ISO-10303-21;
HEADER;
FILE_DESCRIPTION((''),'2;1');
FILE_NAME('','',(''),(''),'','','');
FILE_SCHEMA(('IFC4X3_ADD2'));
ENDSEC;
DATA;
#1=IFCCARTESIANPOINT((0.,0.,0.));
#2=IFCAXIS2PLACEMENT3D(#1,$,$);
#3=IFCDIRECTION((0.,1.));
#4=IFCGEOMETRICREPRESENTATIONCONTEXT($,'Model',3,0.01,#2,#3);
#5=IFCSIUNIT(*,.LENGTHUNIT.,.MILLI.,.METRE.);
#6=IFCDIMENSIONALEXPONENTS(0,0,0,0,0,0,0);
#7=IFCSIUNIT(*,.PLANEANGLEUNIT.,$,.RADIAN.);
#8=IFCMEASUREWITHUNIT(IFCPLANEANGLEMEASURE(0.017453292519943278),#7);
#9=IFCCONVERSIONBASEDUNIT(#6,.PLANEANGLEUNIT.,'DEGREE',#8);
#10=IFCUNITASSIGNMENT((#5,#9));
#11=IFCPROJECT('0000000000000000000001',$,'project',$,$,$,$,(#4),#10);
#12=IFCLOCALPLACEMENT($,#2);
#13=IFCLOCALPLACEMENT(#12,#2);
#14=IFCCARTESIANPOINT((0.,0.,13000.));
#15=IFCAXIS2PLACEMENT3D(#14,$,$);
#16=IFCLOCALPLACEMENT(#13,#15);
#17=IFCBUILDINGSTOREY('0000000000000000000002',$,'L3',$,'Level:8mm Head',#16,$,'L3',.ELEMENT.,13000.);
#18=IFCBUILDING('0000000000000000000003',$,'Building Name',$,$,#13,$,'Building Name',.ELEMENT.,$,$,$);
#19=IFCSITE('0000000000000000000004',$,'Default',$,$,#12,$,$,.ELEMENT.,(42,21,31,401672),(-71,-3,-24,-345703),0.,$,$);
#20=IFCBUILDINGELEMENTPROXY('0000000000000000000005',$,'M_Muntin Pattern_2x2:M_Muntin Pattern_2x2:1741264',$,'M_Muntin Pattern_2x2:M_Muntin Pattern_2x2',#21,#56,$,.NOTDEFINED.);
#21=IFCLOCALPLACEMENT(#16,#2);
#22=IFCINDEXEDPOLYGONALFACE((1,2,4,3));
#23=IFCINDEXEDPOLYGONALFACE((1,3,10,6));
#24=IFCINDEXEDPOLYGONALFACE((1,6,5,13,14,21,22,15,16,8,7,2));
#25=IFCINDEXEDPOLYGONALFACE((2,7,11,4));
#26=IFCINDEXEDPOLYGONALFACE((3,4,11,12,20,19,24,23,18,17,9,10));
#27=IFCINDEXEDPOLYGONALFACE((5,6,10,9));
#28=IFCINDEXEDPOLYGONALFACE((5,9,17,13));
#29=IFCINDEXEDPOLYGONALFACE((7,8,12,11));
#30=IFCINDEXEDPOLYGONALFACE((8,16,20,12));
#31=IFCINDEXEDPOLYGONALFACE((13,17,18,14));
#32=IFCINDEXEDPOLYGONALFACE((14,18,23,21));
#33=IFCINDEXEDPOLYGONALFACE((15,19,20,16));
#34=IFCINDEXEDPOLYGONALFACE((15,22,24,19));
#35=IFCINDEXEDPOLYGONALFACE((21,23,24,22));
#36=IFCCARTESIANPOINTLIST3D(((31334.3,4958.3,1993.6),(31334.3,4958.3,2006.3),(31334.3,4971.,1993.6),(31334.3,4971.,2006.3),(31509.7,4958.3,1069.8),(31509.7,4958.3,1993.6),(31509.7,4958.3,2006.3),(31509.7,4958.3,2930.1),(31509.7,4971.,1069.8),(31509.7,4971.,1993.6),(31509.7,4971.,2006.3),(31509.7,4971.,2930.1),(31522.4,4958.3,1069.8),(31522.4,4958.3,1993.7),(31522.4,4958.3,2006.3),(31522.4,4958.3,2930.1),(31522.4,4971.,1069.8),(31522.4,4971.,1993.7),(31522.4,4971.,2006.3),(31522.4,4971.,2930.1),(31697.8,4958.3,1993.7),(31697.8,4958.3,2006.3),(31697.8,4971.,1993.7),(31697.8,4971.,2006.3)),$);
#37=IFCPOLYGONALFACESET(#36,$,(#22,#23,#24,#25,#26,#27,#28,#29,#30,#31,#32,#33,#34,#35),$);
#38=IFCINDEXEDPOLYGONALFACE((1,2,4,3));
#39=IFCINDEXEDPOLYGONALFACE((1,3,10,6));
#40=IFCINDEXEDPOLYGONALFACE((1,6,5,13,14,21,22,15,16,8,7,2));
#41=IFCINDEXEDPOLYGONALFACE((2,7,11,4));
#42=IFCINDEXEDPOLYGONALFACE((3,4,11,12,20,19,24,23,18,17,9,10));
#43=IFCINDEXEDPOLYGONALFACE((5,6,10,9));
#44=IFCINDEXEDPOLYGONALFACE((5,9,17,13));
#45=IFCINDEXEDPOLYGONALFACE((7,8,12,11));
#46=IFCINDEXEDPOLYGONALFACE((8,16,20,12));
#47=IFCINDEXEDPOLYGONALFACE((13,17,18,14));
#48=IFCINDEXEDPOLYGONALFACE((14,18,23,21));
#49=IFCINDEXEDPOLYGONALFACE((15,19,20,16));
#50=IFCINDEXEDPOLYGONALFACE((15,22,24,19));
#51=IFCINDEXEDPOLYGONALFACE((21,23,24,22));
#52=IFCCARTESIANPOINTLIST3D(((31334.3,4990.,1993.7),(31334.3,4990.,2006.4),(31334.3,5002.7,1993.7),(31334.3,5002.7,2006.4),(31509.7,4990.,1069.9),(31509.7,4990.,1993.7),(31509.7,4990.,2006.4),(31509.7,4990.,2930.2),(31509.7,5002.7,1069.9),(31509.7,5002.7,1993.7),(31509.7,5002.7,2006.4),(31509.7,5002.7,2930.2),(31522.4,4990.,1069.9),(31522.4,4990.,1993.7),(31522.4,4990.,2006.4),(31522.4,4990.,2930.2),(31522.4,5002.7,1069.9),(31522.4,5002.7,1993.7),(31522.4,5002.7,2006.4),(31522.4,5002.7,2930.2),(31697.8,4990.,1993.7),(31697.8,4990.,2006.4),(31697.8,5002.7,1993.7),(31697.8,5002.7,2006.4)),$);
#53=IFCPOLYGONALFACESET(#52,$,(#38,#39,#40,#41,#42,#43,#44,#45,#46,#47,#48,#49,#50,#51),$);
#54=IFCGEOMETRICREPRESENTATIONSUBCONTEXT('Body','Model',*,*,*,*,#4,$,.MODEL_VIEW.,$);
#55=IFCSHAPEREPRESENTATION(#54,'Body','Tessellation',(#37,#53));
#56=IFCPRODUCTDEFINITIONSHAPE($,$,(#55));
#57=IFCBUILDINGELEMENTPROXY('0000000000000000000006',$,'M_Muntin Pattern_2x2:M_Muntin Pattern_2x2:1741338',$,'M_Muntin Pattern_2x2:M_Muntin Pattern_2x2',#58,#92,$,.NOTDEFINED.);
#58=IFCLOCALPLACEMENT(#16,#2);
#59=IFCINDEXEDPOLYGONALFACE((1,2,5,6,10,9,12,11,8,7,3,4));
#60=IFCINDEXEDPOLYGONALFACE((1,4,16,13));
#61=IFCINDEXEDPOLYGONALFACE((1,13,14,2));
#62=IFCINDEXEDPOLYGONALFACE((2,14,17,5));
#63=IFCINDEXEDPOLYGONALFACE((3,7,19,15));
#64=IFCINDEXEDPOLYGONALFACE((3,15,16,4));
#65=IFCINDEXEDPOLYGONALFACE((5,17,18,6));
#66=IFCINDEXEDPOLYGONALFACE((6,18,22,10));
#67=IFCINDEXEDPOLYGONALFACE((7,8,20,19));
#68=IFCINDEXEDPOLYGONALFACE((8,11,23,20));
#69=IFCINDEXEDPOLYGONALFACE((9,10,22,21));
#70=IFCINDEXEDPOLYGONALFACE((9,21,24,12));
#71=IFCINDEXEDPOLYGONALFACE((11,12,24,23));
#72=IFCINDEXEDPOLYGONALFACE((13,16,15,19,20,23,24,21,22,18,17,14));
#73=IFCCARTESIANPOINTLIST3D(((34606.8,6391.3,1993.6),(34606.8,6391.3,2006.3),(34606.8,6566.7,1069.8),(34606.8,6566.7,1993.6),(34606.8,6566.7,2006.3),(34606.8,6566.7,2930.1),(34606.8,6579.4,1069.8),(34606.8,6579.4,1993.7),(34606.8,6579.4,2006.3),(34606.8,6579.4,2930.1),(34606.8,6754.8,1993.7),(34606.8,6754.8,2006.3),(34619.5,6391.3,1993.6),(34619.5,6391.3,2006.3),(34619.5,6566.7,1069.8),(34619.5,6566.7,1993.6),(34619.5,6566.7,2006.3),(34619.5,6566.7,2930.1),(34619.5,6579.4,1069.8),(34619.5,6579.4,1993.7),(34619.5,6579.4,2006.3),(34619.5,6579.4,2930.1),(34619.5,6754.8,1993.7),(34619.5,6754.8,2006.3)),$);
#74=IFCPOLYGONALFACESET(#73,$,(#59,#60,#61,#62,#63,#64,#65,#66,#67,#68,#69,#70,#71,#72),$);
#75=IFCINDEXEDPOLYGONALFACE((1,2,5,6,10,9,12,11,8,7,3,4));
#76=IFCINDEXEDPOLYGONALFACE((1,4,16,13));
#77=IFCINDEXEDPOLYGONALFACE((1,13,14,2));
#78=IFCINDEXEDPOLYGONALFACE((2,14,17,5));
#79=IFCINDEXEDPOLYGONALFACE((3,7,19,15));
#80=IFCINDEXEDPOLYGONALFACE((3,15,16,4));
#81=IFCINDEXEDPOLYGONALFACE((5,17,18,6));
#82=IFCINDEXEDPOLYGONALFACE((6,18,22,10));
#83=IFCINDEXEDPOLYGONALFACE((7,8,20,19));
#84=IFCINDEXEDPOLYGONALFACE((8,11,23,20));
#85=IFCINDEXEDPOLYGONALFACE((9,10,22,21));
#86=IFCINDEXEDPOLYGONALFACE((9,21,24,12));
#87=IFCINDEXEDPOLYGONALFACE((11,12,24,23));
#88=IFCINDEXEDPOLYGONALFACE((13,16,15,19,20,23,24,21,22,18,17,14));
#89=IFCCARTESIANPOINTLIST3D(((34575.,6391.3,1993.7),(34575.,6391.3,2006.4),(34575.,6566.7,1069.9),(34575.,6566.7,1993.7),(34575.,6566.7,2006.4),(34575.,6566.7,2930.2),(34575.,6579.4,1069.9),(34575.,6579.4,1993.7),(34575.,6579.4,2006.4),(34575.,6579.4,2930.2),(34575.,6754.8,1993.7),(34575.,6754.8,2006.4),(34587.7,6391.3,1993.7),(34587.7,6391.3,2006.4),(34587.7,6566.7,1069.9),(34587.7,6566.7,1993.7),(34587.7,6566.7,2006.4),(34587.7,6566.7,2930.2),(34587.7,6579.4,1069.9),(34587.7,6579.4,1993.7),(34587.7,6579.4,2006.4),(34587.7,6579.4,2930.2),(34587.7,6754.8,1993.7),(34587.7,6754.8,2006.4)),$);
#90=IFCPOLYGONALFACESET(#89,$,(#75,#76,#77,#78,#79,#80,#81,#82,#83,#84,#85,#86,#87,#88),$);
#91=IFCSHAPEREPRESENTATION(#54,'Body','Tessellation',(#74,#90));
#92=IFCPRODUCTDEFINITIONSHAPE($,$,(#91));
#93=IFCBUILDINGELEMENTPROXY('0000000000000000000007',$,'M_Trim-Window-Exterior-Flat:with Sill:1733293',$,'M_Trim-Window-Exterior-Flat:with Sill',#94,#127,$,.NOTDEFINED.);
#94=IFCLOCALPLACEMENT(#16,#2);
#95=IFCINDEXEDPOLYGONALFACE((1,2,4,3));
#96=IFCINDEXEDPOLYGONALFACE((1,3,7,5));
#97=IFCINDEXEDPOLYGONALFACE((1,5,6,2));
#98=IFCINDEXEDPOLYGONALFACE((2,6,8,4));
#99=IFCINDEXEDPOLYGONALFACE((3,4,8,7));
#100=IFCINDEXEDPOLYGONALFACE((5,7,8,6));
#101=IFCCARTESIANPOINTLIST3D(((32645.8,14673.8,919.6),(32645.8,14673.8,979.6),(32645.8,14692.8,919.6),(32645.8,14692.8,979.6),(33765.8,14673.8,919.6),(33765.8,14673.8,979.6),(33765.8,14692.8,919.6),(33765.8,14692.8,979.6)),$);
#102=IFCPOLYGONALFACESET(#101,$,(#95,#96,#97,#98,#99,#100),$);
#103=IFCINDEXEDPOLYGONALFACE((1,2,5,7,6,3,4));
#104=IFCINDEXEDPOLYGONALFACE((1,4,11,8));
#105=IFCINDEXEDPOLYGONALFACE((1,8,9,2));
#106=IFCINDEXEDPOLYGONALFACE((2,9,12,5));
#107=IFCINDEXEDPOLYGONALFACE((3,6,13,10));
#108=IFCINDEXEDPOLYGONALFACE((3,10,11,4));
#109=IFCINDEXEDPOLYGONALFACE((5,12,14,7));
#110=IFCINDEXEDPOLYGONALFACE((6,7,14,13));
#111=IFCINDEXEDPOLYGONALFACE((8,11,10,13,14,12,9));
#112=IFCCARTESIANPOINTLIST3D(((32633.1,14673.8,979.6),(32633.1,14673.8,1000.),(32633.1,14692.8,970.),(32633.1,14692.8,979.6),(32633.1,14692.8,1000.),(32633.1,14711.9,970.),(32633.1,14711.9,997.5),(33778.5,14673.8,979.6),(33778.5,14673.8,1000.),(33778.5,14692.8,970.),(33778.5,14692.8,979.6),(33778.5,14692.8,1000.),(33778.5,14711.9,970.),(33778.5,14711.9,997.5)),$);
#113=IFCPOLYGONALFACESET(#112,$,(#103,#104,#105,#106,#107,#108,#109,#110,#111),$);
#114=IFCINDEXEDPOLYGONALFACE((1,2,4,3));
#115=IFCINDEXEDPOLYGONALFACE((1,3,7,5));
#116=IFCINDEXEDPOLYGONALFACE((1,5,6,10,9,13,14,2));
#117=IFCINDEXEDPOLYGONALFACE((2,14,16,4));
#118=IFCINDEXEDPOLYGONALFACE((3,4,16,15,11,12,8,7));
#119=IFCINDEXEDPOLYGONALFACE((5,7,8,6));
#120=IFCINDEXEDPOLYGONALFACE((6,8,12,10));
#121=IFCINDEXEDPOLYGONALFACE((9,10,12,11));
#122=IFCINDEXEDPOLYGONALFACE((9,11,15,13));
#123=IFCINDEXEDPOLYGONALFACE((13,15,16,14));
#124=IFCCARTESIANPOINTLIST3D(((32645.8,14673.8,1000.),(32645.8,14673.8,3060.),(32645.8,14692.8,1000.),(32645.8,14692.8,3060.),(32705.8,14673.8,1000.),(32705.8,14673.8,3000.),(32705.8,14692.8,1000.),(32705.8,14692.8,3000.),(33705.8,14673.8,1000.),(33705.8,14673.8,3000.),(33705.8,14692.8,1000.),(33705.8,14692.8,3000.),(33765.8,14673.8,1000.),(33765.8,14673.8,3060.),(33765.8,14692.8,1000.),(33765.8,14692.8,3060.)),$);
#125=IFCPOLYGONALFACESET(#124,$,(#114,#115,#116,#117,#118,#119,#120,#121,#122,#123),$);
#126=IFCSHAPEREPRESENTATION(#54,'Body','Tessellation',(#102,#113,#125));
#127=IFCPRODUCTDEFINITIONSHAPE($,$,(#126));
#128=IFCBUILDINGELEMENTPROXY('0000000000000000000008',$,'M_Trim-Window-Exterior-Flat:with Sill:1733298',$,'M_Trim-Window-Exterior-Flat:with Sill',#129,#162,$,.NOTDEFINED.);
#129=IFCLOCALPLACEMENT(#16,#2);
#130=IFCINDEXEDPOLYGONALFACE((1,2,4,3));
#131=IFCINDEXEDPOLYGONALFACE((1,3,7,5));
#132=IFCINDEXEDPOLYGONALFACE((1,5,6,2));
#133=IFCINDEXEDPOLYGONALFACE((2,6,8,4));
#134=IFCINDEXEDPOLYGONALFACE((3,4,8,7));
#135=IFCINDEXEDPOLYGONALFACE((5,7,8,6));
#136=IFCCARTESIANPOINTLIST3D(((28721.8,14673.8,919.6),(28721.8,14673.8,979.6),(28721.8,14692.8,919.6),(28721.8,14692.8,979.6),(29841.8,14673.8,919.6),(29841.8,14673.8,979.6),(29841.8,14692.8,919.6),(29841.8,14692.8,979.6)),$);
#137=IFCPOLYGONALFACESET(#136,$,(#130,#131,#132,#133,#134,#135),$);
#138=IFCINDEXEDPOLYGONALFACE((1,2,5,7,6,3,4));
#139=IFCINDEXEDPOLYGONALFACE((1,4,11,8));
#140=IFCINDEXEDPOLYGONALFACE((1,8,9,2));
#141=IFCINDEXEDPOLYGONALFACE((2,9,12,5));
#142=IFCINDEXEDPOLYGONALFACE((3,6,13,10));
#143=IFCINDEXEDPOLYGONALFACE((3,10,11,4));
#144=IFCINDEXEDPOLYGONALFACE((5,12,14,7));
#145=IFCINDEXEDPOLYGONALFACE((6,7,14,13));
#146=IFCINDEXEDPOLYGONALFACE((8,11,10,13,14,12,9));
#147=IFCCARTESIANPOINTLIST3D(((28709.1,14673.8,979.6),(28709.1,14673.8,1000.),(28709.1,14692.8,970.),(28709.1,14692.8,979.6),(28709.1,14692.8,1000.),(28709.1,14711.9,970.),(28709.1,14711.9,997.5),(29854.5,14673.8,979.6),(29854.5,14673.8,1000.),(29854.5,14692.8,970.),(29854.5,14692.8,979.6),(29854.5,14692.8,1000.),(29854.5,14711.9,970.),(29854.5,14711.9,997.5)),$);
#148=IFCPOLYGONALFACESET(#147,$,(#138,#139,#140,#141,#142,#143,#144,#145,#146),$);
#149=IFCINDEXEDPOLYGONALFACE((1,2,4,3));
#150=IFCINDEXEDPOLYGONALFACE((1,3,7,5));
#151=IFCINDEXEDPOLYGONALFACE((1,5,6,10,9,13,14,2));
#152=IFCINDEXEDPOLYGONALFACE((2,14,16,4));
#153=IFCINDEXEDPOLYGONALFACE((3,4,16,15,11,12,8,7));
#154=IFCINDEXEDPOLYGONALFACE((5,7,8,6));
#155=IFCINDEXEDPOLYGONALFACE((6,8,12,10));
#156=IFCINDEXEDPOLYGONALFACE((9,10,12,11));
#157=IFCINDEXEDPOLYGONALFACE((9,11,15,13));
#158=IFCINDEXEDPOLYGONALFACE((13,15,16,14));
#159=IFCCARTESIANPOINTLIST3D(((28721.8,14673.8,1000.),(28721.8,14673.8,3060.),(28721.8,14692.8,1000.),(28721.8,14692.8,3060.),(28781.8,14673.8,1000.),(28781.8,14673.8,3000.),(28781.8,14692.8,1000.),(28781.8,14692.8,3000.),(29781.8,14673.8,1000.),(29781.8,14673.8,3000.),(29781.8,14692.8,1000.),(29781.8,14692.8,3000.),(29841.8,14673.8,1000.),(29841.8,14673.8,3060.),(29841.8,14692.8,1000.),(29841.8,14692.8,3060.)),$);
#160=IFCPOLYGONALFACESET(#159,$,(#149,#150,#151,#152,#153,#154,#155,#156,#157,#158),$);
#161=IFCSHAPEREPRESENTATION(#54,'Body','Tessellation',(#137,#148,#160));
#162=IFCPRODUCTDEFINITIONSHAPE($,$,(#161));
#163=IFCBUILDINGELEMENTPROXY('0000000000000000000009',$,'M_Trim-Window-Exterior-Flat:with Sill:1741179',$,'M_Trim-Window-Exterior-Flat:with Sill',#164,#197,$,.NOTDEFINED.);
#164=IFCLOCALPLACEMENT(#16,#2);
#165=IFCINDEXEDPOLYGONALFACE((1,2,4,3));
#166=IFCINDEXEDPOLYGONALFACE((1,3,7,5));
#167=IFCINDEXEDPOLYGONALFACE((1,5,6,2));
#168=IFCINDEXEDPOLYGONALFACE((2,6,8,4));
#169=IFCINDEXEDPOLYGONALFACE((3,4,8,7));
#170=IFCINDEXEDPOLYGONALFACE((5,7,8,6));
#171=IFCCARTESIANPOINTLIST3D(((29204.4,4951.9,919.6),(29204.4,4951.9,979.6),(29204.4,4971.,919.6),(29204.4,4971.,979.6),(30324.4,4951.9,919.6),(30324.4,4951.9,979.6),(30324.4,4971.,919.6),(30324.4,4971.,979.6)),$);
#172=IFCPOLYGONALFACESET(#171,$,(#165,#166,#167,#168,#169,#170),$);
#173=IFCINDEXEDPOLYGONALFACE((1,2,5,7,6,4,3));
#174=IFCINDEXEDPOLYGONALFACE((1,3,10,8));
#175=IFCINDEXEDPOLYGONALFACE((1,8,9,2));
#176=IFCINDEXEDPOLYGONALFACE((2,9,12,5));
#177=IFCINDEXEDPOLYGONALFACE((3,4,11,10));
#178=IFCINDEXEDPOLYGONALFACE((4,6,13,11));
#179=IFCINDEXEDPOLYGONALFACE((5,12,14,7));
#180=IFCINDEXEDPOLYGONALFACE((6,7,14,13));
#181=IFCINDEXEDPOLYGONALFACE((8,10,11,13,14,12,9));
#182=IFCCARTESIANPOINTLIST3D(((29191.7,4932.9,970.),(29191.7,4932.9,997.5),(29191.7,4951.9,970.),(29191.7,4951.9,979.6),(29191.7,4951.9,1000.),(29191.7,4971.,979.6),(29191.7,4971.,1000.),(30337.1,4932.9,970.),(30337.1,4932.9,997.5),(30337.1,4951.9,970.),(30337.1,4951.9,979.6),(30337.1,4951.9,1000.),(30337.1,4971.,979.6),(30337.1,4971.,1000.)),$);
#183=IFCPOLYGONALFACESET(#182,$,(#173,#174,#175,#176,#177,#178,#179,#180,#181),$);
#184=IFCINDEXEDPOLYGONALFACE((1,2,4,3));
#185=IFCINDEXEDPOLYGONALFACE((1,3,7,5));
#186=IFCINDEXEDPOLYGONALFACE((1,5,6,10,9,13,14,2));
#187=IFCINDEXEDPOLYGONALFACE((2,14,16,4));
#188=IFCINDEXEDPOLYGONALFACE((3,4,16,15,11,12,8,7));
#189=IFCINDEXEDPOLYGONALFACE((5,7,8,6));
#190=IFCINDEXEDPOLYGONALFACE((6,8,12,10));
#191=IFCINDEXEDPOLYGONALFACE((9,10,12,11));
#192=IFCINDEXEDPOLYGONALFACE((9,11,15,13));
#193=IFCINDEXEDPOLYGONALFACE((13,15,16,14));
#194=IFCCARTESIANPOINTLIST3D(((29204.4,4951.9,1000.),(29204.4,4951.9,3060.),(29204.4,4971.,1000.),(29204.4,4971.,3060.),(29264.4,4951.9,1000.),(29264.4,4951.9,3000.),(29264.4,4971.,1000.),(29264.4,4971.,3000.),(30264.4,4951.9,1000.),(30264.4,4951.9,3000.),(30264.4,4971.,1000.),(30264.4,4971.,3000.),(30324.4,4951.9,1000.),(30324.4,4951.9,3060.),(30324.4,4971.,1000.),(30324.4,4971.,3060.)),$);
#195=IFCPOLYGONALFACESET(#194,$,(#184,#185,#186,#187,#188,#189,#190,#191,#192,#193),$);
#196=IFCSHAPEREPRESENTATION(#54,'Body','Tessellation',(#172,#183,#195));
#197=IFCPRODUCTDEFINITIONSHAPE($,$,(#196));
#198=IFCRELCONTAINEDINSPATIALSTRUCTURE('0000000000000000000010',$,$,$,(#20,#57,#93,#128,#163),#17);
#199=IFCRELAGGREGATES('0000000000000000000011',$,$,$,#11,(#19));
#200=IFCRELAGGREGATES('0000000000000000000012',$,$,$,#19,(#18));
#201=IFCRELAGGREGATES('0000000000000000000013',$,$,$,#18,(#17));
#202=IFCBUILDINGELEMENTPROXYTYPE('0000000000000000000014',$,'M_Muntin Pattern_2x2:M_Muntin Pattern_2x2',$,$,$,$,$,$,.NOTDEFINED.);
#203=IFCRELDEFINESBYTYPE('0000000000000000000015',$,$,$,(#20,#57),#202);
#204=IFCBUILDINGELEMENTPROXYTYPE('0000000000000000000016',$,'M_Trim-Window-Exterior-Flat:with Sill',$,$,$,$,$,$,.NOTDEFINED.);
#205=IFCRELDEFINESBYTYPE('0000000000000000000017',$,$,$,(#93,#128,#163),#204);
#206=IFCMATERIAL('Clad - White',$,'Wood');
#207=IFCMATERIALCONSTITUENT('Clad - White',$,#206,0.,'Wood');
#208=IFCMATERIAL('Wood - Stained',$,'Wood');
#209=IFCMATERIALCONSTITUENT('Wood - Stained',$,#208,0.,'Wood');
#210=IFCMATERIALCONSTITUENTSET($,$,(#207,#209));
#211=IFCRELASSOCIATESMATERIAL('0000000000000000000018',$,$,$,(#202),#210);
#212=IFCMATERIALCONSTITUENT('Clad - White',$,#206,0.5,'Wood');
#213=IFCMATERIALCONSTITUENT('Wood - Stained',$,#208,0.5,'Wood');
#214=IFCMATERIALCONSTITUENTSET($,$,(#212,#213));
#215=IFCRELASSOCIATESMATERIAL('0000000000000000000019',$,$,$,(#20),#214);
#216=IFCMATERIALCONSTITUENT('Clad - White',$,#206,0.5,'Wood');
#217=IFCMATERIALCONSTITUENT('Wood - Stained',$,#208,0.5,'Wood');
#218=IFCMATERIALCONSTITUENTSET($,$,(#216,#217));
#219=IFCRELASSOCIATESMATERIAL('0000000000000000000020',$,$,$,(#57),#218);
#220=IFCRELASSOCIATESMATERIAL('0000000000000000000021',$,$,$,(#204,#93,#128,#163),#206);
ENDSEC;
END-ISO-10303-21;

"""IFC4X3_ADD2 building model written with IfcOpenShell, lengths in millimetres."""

from ifc_helpers import new_model, entity, si_unit, converted_unit, direction, frame, frame_2d, origin, place, context, subcontext, project, spatial, polyline, rectangle, outline, extrude, source, transform, mapped, material, constituent, constituent_set, type_object, type_shapes, element, save


model = new_model("IFC4X3_ADD2")

# Units and contexts
model_context = context("Model", 3, precision=0.01, world=origin(), true_north=direction((0.0, 1.0)))
body_context = subcontext(model_context, "Body", "Model", "MODEL_VIEW")
ifc_project = project(units=[si_unit("LENGTHUNIT", "METRE", prefix="MILLI"), converted_unit("PLANEANGLEUNIT", "DEGREE", entity("IfcPlaneAngleMeasure", 0.017453292519943278), si_unit("PLANEANGLEUNIT", "RADIAN"), dimensions=[0, 0, 0, 0, 0, 0, 0])], contexts=[model_context])

# Site, building, storey
site_placement = place(None, origin())
site = spatial("IfcSite", under=ifc_project, at=site_placement, Name="Default", CompositionType="ELEMENT", RefLatitude=(42, 21, 31, 401672), RefLongitude=(-71, -3, -24, -345703), RefElevation=0.0)
building_placement = place(site_placement, origin())
building = spatial("IfcBuilding", under=site, at=building_placement, Name="Building Name", LongName="Building Name", CompositionType="ELEMENT")
storey_placement = place(building_placement, frame((0.0, 0.0, 13000.0)))
storey = spatial("IfcBuildingStorey", under=building, at=storey_placement, Name="L3", ObjectType="Level:8mm Head", LongName="L3", CompositionType="ELEMENT", Elevation=13000.0)

# Building element proxies
ifc_material_1 = material(Name="Clad - White", Category="Wood")
ifc_material_2 = material(Name="Wood - Stained", Category="Wood")
ifc_constituent_1 = constituent(ifc_material_1, Name="Clad - White", Category="Wood", fraction=0.0)
ifc_constituent_2 = constituent(ifc_material_2, Name="Wood - Stained", Category="Wood", fraction=0.0)
ifc_constituent_set_1 = constituent_set(constituents=[ifc_constituent_1, ifc_constituent_2])
building_element_proxy_type_1 = type_object("IfcBuildingElementProxyType", Name="M_Muntin Pattern_2x2:M_Muntin Pattern_2x2", PredefinedType="NOTDEFINED", material=ifc_constituent_set_1)
shared_shape_1 = source(origin(), body_context, "Body", "SweptSolid", [
    extrude(outline(polyline([(6.4, -6.4), (930.1, -6.4), (930.1, 6.3), (6.4, 6.3), (6.4, 181.7), (-6.3, 181.7), (-6.3, 6.3), (-930.2, 6.3), (-930.2, -6.4), (-6.3, -6.4), (-6.3, -181.7), (6.4, -181.7), (6.4, -6.4)])), frame((0.0, -22.2, 930.1), z_axis=(0.0, 1.0, 0.0), x_axis=(0.0, 0.0, 1.0)), (0.0, 0.0, 1.0), 12.7),
    extrude(outline(polyline([(6.4, -6.4), (930.2, -6.4), (930.2, 6.3), (6.4, 6.3), (6.4, 181.7), (-6.3, 181.7), (-6.3, 6.3), (-930.2, 6.3), (-930.2, -6.4), (-6.3, -6.4), (-6.3, -181.7), (6.4, -181.7), (6.4, -6.4)])), frame((0.0, 9.5, 930.2), z_axis=(0.0, 1.0, 0.0), x_axis=(0.0, 0.0, 1.0)), (0.0, 0.0, 1.0), 12.7),
])
type_shapes(building_element_proxy_type_1, [shared_shape_1])
ifc_constituent_3 = constituent(ifc_material_1, Name="Clad - White", Category="Wood", fraction=0.5)
ifc_constituent_4 = constituent(ifc_material_2, Name="Wood - Stained", Category="Wood", fraction=0.5)
ifc_constituent_set_2 = constituent_set(constituents=[ifc_constituent_3, ifc_constituent_4])
proxy_1_placement = place(storey_placement, frame((31516.0, 4980.5, 1069.9)))
element("IfcBuildingElementProxy", 1, at=proxy_1_placement, inside=storey, type_object=building_element_proxy_type_1, material=ifc_constituent_set_2, Name="M_Muntin Pattern_2x2:M_Muntin Pattern_2x2:1741264", ObjectType="M_Muntin Pattern_2x2:M_Muntin Pattern_2x2", PredefinedType="NOTDEFINED", context=body_context, shape_type="MappedRepresentation", body=[
    mapped(shared_shape_1, transform((0.0, 0.0, 0.0), scale=1.0)),
])
ifc_constituent_5 = constituent(ifc_material_1, Name="Clad - White", Category="Wood", fraction=0.5)
ifc_constituent_6 = constituent(ifc_material_2, Name="Wood - Stained", Category="Wood", fraction=0.5)
ifc_constituent_set_3 = constituent_set(constituents=[ifc_constituent_5, ifc_constituent_6])
proxy_2_placement = place(storey_placement, frame((34597.3, 6573.1, 1069.9), z_axis=(0.0, 0.0, 1.0), x_axis=(0.0, 1.0, 0.0)))
element("IfcBuildingElementProxy", 2, at=proxy_2_placement, inside=storey, type_object=building_element_proxy_type_1, material=ifc_constituent_set_3, Name="M_Muntin Pattern_2x2:M_Muntin Pattern_2x2:1741338", ObjectType="M_Muntin Pattern_2x2:M_Muntin Pattern_2x2", PredefinedType="NOTDEFINED", context=body_context, shape_type="MappedRepresentation", body=[
    mapped(shared_shape_1, transform((0.0, 0.0, 0.0), scale=1.0)),
])
building_element_proxy_type_2 = type_object("IfcBuildingElementProxyType", Name="M_Trim-Window-Exterior-Flat:with Sill", PredefinedType="NOTDEFINED", material=ifc_material_1)
shared_shape_2 = source(origin(), body_context, "Body", "SweptSolid", [
    extrude(rectangle(XDim=1120.0, YDim=60.0, at=frame_2d((0.0, 0.0), x_axis=(1.0, 0.0))), frame((0.0, -2050.4, 0.0), z_axis=(0.0, 0.0, 1.0), x_axis=(-1.0, 0.0, 0.0)), (0.0, 0.0, 1.0), 19.0),
    extrude(outline(polyline([(-19.0, -15.2), (0.0, -15.2), (0.0, -5.7), (19.0, -5.7), (19.0, 14.8), (0.0, 14.8), (-19.0, 12.3), (-19.0, -15.2)])), frame((-572.7, -2014.8, 19.0), z_axis=(1.0, 0.0, 0.0), x_axis=(0.0, 0.0, -1.0)), (0.0, 0.0, 1.0), 1145.4),
    extrude(outline(polyline([(-1045.0, -560.0), (1015.0, -560.0), (1015.0, -500.0), (-985.0, -500.0), (-985.0, 500.0), (1015.0, 500.0), (1015.0, 560.0), (-1045.0, 560.0), (-1045.0, -560.0)])), frame((0.0, -985.0, 0.0), z_axis=(0.0, 0.0, 1.0), x_axis=(0.0, -1.0, 0.0)), (0.0, 0.0, 1.0), 19.0),
])
type_shapes(building_element_proxy_type_2, [shared_shape_2])
for number, where, z_axis, x_axis, name in (
    (3, (33205.8, 14673.8, 3000.0), (0.0, 1.0, 0.0), (-1.0, 0.0, 0.0), "M_Trim-Window-Exterior-Flat:with Sill:1733293"),
    (4, (29281.8, 14673.8, 3000.0), (0.0, 1.0, 0.0), (-1.0, 0.0, 0.0), "M_Trim-Window-Exterior-Flat:with Sill:1733298"),
    (5, (29764.4, 4971.0, 3000.0), (0.0, -1.0, 0.0), (1.0, 0.0, 0.0), "M_Trim-Window-Exterior-Flat:with Sill:1741179"),
):
    element("IfcBuildingElementProxy", number, at=place(storey_placement, frame(where, z_axis=z_axis, x_axis=x_axis)), inside=storey, type_object=building_element_proxy_type_2, material=ifc_material_1, Name=name, ObjectType="M_Trim-Window-Exterior-Flat:with Sill", PredefinedType="NOTDEFINED", context=body_context, shape_type="MappedRepresentation", body=[
        mapped(shared_shape_2, transform((0.0, 0.0, 0.0), scale=1.0)),
    ])

save(model, "model.ifc")
